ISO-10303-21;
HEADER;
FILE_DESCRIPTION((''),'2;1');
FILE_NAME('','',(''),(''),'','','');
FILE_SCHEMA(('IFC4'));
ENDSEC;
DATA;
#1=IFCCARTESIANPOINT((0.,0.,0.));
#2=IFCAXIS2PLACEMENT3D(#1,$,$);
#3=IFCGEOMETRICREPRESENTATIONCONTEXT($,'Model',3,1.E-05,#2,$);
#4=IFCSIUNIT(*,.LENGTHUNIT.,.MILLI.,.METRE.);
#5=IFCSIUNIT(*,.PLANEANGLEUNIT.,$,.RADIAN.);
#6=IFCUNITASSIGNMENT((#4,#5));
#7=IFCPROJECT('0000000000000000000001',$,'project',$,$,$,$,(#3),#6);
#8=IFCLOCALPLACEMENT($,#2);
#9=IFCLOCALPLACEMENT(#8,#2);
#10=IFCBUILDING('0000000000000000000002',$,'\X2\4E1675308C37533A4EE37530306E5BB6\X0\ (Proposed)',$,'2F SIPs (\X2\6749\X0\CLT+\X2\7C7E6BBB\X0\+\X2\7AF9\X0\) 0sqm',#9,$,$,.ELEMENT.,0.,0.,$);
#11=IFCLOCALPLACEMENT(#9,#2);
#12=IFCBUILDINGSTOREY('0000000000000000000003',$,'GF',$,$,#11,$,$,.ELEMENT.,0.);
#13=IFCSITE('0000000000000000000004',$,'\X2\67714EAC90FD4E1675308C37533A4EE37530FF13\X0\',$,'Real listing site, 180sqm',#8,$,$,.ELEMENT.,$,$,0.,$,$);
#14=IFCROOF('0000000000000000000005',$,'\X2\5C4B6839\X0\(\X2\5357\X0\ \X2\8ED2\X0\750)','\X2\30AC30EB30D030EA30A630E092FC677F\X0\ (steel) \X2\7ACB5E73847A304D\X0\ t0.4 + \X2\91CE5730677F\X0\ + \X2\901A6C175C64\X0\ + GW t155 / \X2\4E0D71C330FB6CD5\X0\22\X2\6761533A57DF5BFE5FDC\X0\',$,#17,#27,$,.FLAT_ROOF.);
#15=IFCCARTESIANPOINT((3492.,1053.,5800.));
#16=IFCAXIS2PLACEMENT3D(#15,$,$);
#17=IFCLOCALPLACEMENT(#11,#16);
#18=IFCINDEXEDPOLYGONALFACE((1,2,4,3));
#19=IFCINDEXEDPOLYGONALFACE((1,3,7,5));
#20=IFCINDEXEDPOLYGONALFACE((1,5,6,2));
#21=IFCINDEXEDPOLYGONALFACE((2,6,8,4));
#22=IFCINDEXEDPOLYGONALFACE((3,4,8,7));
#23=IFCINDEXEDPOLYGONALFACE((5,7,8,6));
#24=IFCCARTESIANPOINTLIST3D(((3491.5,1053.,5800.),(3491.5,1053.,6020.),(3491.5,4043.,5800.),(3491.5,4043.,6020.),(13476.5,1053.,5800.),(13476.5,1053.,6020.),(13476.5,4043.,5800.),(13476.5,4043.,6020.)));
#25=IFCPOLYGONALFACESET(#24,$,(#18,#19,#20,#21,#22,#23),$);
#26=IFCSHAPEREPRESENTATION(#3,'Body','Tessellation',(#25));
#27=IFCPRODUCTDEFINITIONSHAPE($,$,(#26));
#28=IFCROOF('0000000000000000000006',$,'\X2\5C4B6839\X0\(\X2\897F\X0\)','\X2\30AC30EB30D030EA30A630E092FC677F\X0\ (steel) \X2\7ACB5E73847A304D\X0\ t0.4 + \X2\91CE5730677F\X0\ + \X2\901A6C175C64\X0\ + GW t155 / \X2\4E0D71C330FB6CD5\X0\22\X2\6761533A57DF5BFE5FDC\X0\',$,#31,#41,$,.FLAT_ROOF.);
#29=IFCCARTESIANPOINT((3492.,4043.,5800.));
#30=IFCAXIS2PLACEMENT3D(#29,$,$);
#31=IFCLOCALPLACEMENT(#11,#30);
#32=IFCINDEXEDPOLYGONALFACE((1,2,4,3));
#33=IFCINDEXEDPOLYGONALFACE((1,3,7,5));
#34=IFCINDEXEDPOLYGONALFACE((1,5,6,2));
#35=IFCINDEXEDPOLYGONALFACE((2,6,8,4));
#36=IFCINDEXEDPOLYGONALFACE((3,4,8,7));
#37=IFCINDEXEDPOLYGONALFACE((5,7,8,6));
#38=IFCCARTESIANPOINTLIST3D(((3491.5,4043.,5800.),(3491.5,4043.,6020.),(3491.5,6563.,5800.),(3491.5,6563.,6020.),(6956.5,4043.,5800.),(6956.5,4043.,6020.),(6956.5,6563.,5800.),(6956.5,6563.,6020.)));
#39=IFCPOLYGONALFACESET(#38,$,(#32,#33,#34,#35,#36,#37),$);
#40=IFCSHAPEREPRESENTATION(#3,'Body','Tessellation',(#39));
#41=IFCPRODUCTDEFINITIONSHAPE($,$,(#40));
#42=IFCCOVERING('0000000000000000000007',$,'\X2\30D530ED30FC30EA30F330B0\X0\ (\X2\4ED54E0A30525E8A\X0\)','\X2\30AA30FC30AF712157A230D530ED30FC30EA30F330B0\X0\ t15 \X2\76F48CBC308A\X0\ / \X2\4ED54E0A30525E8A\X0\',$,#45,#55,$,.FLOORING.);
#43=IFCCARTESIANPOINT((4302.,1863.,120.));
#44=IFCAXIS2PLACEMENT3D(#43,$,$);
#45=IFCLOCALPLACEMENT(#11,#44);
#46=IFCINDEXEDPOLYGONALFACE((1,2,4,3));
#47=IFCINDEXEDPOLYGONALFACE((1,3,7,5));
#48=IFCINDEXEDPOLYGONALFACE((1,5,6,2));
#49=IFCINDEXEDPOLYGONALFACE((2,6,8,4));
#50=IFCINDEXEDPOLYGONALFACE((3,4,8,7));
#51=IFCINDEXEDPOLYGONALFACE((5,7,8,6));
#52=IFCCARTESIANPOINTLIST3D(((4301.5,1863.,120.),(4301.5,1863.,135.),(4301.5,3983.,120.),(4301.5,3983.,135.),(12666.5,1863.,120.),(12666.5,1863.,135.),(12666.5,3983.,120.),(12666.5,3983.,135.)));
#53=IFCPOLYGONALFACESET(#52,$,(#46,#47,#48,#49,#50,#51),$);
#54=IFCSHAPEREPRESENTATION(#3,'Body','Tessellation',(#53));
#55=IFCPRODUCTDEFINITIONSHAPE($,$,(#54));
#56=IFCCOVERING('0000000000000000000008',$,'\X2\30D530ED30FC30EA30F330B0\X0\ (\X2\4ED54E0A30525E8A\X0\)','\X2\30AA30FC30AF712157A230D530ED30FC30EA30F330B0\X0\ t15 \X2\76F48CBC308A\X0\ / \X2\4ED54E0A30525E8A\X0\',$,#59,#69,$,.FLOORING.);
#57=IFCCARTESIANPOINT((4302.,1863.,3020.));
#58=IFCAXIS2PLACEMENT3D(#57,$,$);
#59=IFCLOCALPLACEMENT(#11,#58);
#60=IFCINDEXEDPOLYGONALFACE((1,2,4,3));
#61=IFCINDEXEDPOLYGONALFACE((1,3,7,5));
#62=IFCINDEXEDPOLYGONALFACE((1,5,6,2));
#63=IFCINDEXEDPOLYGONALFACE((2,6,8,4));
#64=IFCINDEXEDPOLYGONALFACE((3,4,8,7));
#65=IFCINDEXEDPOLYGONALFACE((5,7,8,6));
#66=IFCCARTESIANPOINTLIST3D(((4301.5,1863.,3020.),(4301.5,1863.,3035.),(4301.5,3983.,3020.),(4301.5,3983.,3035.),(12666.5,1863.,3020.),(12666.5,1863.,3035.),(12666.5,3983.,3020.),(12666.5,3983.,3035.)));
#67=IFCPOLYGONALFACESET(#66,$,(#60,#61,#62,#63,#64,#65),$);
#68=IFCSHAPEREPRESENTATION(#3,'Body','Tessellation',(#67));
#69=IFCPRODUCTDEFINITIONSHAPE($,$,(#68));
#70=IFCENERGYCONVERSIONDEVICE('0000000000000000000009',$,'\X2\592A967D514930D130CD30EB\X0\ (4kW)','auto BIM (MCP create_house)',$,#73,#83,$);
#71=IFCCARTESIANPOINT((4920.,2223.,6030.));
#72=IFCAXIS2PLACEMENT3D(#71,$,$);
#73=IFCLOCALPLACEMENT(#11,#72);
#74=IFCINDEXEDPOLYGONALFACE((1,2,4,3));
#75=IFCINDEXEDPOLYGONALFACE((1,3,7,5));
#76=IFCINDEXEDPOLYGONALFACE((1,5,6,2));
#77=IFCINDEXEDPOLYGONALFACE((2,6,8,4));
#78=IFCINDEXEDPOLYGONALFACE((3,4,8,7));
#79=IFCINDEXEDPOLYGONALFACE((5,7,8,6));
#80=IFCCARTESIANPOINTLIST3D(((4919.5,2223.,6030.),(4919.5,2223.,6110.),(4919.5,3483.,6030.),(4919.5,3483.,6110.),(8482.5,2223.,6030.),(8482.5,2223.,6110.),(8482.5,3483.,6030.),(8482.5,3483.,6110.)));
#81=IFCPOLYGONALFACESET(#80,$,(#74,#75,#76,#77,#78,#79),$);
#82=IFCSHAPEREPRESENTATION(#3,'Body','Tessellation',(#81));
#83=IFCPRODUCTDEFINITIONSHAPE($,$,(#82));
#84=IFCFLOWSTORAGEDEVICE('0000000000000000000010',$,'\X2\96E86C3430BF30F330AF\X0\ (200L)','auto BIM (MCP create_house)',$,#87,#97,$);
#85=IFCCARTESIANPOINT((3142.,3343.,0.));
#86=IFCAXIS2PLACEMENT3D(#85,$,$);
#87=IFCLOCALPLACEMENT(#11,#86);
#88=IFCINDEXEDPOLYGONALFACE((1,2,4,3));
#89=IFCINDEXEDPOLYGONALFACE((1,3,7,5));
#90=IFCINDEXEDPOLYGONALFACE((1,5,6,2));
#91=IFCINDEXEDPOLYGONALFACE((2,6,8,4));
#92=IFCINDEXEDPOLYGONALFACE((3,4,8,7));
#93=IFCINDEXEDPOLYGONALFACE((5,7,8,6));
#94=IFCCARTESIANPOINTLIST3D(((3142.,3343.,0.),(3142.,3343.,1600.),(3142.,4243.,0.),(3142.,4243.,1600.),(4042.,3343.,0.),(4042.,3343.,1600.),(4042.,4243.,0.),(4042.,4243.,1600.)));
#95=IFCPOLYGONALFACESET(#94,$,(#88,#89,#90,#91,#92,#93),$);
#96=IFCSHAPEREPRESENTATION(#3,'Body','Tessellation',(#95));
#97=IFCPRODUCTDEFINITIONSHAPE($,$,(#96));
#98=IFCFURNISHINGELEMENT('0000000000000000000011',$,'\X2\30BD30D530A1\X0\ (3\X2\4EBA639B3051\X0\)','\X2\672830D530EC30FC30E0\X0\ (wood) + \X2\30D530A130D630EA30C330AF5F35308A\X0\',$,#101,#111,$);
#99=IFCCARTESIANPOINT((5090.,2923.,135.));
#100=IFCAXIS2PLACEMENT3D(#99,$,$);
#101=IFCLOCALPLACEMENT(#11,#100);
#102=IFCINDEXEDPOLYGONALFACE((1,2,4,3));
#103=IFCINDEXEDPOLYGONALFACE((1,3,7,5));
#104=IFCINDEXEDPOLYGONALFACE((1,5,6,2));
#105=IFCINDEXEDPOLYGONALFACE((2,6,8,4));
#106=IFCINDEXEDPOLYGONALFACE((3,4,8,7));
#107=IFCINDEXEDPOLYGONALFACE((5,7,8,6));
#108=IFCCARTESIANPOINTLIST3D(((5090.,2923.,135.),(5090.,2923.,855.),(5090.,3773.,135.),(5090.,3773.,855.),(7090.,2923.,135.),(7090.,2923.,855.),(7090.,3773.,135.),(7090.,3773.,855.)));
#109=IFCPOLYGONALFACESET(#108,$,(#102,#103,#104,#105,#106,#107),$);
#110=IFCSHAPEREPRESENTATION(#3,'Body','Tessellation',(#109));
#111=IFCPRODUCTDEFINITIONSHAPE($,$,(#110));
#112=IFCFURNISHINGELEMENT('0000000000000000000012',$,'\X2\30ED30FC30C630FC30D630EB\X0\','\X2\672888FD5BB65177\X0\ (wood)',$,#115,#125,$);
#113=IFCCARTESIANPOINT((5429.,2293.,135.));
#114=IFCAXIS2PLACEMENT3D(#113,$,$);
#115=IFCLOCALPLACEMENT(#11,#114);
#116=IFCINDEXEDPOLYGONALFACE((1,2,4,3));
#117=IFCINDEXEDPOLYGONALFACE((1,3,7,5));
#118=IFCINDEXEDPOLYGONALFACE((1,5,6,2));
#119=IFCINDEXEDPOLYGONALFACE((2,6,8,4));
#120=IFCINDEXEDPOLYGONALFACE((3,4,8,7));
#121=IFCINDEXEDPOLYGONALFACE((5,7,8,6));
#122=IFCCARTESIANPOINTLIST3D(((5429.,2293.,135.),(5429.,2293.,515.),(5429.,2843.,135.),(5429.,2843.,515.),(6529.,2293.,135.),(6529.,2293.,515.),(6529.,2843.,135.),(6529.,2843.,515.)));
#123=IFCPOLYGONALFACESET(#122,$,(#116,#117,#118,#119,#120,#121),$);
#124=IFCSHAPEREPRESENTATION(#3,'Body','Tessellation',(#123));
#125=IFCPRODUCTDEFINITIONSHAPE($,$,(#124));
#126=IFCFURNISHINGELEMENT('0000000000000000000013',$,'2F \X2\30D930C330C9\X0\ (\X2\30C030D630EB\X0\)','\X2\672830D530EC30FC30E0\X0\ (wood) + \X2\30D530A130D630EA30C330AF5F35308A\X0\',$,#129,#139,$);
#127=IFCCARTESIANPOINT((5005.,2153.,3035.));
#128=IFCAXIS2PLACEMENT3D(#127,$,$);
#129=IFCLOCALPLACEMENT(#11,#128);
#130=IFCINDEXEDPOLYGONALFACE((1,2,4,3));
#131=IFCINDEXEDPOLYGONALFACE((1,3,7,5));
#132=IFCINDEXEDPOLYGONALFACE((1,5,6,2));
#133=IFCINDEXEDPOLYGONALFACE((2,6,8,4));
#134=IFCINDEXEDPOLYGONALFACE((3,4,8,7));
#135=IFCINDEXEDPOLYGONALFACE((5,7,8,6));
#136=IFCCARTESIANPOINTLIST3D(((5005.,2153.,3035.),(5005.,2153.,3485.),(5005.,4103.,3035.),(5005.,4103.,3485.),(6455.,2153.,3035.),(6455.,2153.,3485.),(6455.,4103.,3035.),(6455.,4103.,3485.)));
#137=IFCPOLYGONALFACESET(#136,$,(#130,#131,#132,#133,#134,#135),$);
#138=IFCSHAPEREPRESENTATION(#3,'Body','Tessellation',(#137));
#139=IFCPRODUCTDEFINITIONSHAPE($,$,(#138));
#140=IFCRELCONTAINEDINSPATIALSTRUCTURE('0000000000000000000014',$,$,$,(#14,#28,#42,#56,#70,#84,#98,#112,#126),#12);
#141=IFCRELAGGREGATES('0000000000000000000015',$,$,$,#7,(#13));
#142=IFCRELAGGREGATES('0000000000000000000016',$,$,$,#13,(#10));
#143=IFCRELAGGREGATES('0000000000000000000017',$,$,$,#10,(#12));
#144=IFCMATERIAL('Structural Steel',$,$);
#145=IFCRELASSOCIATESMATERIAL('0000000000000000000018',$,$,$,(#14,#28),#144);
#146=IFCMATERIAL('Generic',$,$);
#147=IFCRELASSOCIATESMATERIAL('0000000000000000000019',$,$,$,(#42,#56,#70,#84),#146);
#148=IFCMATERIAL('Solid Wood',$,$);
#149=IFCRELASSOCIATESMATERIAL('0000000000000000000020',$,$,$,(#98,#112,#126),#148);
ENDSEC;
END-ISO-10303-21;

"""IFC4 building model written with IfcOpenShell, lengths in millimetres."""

from ifc_helpers import new_model, si_unit, frame, frame_2d, origin, place, context, project, spatial, rectangle, extrude, material, element, save


model = new_model("IFC4")

# Units and contexts
model_context = context("Model", 3, precision=1e-05, world=origin())
ifc_project = project(units=[si_unit("LENGTHUNIT", "METRE", prefix="MILLI"), si_unit("PLANEANGLEUNIT", "RADIAN")], contexts=[model_context])

# Site, building, storey
site_placement = place(None, origin())
site = spatial("IfcSite", under=ifc_project, at=site_placement, Name="東京都世田谷区代田３", ObjectType="Real listing site, 180sqm", CompositionType="ELEMENT", RefElevation=0.0)
building_placement = place(site_placement, origin())
building = spatial("IfcBuilding", under=site, at=building_placement, Name="世田谷区代田の家 (Proposed)", ObjectType="2F SIPs (杉CLT+籾殻+竹) 0sqm", CompositionType="ELEMENT", ElevationOfRefHeight=0.0, ElevationOfTerrain=0.0)
storey_placement = place(building_placement, origin())
storey = spatial("IfcBuildingStorey", under=building, at=storey_placement, Name="GF", CompositionType="ELEMENT", Elevation=0.0)

# Shared definitions
ifc_material_1 = material(Name="Solid Wood")

# Roofs
ifc_material_2 = material(Name="Structural Steel")
roof_1_placement = place(storey_placement, frame((3492.0, 1053.0, 5800.0)))
element("IfcRoof", 1, at=roof_1_placement, inside=storey, material=ifc_material_2, Name="屋根(南 軒750)", Description="ガルバリウム鋼板 (steel) 立平葺き t0.4 + 野地板 + 通気層 + GW t155 / 不燃・法22条区域対応", PredefinedType="FLAT_ROOF", context=model_context, shape_type="SweptSolid", body=[
    extrude(rectangle(XDim=9985.0, YDim=2990.0, at=frame_2d((4992.0, 1495.0))), frame((3492.0, 1053.0, 5800.0)), (0.0, 0.0, 1.0), 220.0),
])
roof_2_placement = place(storey_placement, frame((3492.0, 4043.0, 5800.0)))
element("IfcRoof", 2, at=roof_2_placement, inside=storey, material=ifc_material_2, Name="屋根(西)", Description="ガルバリウム鋼板 (steel) 立平葺き t0.4 + 野地板 + 通気層 + GW t155 / 不燃・法22条区域対応", PredefinedType="FLAT_ROOF", context=model_context, shape_type="SweptSolid", body=[
    extrude(rectangle(XDim=3465.0, YDim=2520.0, at=frame_2d((1732.0, 1260.0))), frame((3492.0, 4043.0, 5800.0)), (0.0, 0.0, 1.0), 220.0),
])

# Coverings
ifc_material_3 = material(Name="Generic")
covering_1_placement = place(storey_placement, frame((4302.0, 1863.0, 120.0)))
element("IfcCovering", 3, at=covering_1_placement, inside=storey, material=ifc_material_3, Name="フローリング (仕上げ床)", Description="オーク無垢フローリング t15 直貼り / 仕上げ床", PredefinedType="FLOORING", context=model_context, shape_type="SweptSolid", body=[
    extrude(rectangle(XDim=8365.0, YDim=2120.0, at=frame_2d((4182.0, 1060.0))), frame((4302.0, 1863.0, 120.0)), (0.0, 0.0, 1.0), 15.0),
])
covering_2_placement = place(storey_placement, frame((4302.0, 1863.0, 3020.0)))
element("IfcCovering", 4, at=covering_2_placement, inside=storey, material=ifc_material_3, Name="フローリング (仕上げ床)", Description="オーク無垢フローリング t15 直貼り / 仕上げ床", PredefinedType="FLOORING", context=model_context, shape_type="SweptSolid", body=[
    extrude(rectangle(XDim=8365.0, YDim=2120.0, at=frame_2d((4182.0, 1060.0))), frame((4302.0, 1863.0, 3020.0)), (0.0, 0.0, 1.0), 15.0),
])

# Energy conversion device
energy_conversion_device_placement = place(storey_placement, frame((4920.0, 2223.0, 6030.0)))
element("IfcEnergyConversionDevice", 5, at=energy_conversion_device_placement, inside=storey, material=ifc_material_3, Name="太陽光パネル (4kW)", Description="auto BIM (MCP create_house)", context=model_context, shape_type="SweptSolid", body=[
    extrude(rectangle(XDim=3563.0, YDim=1260.0, at=frame_2d((1781.0, 630.0))), frame((4920.0, 2223.0, 6030.0)), (0.0, 0.0, 1.0), 80.0),
])

# Flow storage device
flow_storage_device_placement = place(storey_placement, frame((3142.0, 3343.0, 0.0)))
element("IfcFlowStorageDevice", 6, at=flow_storage_device_placement, inside=storey, material=ifc_material_3, Name="雨水タンク (200L)", Description="auto BIM (MCP create_house)", context=model_context, shape_type="SweptSolid", body=[
    extrude(rectangle(XDim=900.0, YDim=900.0, at=frame_2d((450.0, 450.0))), frame((3142.0, 3343.0, 0.0)), (0.0, 0.0, 1.0), 1600.0),
])

# Furnishing elements
furnishing_1_placement = place(storey_placement, frame((5090.0, 2923.0, 135.0)))
element("IfcFurnishingElement", 7, at=furnishing_1_placement, inside=storey, material=ifc_material_1, Name="ソファ (3人掛け)", Description="木フレーム (wood) + ファブリック張り", context=model_context, shape_type="SweptSolid", body=[
    extrude(rectangle(XDim=2000.0, YDim=850.0, at=frame_2d((1000.0, 425.0))), frame((5090.0, 2923.0, 135.0)), (0.0, 0.0, 1.0), 720.0),
])
furnishing_2_placement = place(storey_placement, frame((5429.0, 2293.0, 135.0)))
element("IfcFurnishingElement", 8, at=furnishing_2_placement, inside=storey, material=ifc_material_1, Name="ローテーブル", Description="木製家具 (wood)", context=model_context, shape_type="SweptSolid", body=[
    extrude(rectangle(XDim=1100.0, YDim=550.0, at=frame_2d((550.0, 275.0))), frame((5429.0, 2293.0, 135.0)), (0.0, 0.0, 1.0), 380.0),
])
furnishing_3_placement = place(storey_placement, frame((5005.0, 2153.0, 3035.0)))
element("IfcFurnishingElement", 9, at=furnishing_3_placement, inside=storey, material=ifc_material_1, Name="2F ベッド (ダブル)", Description="木フレーム (wood) + ファブリック張り", context=model_context, shape_type="SweptSolid", body=[
    extrude(rectangle(XDim=1450.0, YDim=1950.0, at=frame_2d((725.0, 975.0))), frame((5005.0, 2153.0, 3035.0)), (0.0, 0.0, 1.0), 450.0),
])

save(model, "model.ifc")
